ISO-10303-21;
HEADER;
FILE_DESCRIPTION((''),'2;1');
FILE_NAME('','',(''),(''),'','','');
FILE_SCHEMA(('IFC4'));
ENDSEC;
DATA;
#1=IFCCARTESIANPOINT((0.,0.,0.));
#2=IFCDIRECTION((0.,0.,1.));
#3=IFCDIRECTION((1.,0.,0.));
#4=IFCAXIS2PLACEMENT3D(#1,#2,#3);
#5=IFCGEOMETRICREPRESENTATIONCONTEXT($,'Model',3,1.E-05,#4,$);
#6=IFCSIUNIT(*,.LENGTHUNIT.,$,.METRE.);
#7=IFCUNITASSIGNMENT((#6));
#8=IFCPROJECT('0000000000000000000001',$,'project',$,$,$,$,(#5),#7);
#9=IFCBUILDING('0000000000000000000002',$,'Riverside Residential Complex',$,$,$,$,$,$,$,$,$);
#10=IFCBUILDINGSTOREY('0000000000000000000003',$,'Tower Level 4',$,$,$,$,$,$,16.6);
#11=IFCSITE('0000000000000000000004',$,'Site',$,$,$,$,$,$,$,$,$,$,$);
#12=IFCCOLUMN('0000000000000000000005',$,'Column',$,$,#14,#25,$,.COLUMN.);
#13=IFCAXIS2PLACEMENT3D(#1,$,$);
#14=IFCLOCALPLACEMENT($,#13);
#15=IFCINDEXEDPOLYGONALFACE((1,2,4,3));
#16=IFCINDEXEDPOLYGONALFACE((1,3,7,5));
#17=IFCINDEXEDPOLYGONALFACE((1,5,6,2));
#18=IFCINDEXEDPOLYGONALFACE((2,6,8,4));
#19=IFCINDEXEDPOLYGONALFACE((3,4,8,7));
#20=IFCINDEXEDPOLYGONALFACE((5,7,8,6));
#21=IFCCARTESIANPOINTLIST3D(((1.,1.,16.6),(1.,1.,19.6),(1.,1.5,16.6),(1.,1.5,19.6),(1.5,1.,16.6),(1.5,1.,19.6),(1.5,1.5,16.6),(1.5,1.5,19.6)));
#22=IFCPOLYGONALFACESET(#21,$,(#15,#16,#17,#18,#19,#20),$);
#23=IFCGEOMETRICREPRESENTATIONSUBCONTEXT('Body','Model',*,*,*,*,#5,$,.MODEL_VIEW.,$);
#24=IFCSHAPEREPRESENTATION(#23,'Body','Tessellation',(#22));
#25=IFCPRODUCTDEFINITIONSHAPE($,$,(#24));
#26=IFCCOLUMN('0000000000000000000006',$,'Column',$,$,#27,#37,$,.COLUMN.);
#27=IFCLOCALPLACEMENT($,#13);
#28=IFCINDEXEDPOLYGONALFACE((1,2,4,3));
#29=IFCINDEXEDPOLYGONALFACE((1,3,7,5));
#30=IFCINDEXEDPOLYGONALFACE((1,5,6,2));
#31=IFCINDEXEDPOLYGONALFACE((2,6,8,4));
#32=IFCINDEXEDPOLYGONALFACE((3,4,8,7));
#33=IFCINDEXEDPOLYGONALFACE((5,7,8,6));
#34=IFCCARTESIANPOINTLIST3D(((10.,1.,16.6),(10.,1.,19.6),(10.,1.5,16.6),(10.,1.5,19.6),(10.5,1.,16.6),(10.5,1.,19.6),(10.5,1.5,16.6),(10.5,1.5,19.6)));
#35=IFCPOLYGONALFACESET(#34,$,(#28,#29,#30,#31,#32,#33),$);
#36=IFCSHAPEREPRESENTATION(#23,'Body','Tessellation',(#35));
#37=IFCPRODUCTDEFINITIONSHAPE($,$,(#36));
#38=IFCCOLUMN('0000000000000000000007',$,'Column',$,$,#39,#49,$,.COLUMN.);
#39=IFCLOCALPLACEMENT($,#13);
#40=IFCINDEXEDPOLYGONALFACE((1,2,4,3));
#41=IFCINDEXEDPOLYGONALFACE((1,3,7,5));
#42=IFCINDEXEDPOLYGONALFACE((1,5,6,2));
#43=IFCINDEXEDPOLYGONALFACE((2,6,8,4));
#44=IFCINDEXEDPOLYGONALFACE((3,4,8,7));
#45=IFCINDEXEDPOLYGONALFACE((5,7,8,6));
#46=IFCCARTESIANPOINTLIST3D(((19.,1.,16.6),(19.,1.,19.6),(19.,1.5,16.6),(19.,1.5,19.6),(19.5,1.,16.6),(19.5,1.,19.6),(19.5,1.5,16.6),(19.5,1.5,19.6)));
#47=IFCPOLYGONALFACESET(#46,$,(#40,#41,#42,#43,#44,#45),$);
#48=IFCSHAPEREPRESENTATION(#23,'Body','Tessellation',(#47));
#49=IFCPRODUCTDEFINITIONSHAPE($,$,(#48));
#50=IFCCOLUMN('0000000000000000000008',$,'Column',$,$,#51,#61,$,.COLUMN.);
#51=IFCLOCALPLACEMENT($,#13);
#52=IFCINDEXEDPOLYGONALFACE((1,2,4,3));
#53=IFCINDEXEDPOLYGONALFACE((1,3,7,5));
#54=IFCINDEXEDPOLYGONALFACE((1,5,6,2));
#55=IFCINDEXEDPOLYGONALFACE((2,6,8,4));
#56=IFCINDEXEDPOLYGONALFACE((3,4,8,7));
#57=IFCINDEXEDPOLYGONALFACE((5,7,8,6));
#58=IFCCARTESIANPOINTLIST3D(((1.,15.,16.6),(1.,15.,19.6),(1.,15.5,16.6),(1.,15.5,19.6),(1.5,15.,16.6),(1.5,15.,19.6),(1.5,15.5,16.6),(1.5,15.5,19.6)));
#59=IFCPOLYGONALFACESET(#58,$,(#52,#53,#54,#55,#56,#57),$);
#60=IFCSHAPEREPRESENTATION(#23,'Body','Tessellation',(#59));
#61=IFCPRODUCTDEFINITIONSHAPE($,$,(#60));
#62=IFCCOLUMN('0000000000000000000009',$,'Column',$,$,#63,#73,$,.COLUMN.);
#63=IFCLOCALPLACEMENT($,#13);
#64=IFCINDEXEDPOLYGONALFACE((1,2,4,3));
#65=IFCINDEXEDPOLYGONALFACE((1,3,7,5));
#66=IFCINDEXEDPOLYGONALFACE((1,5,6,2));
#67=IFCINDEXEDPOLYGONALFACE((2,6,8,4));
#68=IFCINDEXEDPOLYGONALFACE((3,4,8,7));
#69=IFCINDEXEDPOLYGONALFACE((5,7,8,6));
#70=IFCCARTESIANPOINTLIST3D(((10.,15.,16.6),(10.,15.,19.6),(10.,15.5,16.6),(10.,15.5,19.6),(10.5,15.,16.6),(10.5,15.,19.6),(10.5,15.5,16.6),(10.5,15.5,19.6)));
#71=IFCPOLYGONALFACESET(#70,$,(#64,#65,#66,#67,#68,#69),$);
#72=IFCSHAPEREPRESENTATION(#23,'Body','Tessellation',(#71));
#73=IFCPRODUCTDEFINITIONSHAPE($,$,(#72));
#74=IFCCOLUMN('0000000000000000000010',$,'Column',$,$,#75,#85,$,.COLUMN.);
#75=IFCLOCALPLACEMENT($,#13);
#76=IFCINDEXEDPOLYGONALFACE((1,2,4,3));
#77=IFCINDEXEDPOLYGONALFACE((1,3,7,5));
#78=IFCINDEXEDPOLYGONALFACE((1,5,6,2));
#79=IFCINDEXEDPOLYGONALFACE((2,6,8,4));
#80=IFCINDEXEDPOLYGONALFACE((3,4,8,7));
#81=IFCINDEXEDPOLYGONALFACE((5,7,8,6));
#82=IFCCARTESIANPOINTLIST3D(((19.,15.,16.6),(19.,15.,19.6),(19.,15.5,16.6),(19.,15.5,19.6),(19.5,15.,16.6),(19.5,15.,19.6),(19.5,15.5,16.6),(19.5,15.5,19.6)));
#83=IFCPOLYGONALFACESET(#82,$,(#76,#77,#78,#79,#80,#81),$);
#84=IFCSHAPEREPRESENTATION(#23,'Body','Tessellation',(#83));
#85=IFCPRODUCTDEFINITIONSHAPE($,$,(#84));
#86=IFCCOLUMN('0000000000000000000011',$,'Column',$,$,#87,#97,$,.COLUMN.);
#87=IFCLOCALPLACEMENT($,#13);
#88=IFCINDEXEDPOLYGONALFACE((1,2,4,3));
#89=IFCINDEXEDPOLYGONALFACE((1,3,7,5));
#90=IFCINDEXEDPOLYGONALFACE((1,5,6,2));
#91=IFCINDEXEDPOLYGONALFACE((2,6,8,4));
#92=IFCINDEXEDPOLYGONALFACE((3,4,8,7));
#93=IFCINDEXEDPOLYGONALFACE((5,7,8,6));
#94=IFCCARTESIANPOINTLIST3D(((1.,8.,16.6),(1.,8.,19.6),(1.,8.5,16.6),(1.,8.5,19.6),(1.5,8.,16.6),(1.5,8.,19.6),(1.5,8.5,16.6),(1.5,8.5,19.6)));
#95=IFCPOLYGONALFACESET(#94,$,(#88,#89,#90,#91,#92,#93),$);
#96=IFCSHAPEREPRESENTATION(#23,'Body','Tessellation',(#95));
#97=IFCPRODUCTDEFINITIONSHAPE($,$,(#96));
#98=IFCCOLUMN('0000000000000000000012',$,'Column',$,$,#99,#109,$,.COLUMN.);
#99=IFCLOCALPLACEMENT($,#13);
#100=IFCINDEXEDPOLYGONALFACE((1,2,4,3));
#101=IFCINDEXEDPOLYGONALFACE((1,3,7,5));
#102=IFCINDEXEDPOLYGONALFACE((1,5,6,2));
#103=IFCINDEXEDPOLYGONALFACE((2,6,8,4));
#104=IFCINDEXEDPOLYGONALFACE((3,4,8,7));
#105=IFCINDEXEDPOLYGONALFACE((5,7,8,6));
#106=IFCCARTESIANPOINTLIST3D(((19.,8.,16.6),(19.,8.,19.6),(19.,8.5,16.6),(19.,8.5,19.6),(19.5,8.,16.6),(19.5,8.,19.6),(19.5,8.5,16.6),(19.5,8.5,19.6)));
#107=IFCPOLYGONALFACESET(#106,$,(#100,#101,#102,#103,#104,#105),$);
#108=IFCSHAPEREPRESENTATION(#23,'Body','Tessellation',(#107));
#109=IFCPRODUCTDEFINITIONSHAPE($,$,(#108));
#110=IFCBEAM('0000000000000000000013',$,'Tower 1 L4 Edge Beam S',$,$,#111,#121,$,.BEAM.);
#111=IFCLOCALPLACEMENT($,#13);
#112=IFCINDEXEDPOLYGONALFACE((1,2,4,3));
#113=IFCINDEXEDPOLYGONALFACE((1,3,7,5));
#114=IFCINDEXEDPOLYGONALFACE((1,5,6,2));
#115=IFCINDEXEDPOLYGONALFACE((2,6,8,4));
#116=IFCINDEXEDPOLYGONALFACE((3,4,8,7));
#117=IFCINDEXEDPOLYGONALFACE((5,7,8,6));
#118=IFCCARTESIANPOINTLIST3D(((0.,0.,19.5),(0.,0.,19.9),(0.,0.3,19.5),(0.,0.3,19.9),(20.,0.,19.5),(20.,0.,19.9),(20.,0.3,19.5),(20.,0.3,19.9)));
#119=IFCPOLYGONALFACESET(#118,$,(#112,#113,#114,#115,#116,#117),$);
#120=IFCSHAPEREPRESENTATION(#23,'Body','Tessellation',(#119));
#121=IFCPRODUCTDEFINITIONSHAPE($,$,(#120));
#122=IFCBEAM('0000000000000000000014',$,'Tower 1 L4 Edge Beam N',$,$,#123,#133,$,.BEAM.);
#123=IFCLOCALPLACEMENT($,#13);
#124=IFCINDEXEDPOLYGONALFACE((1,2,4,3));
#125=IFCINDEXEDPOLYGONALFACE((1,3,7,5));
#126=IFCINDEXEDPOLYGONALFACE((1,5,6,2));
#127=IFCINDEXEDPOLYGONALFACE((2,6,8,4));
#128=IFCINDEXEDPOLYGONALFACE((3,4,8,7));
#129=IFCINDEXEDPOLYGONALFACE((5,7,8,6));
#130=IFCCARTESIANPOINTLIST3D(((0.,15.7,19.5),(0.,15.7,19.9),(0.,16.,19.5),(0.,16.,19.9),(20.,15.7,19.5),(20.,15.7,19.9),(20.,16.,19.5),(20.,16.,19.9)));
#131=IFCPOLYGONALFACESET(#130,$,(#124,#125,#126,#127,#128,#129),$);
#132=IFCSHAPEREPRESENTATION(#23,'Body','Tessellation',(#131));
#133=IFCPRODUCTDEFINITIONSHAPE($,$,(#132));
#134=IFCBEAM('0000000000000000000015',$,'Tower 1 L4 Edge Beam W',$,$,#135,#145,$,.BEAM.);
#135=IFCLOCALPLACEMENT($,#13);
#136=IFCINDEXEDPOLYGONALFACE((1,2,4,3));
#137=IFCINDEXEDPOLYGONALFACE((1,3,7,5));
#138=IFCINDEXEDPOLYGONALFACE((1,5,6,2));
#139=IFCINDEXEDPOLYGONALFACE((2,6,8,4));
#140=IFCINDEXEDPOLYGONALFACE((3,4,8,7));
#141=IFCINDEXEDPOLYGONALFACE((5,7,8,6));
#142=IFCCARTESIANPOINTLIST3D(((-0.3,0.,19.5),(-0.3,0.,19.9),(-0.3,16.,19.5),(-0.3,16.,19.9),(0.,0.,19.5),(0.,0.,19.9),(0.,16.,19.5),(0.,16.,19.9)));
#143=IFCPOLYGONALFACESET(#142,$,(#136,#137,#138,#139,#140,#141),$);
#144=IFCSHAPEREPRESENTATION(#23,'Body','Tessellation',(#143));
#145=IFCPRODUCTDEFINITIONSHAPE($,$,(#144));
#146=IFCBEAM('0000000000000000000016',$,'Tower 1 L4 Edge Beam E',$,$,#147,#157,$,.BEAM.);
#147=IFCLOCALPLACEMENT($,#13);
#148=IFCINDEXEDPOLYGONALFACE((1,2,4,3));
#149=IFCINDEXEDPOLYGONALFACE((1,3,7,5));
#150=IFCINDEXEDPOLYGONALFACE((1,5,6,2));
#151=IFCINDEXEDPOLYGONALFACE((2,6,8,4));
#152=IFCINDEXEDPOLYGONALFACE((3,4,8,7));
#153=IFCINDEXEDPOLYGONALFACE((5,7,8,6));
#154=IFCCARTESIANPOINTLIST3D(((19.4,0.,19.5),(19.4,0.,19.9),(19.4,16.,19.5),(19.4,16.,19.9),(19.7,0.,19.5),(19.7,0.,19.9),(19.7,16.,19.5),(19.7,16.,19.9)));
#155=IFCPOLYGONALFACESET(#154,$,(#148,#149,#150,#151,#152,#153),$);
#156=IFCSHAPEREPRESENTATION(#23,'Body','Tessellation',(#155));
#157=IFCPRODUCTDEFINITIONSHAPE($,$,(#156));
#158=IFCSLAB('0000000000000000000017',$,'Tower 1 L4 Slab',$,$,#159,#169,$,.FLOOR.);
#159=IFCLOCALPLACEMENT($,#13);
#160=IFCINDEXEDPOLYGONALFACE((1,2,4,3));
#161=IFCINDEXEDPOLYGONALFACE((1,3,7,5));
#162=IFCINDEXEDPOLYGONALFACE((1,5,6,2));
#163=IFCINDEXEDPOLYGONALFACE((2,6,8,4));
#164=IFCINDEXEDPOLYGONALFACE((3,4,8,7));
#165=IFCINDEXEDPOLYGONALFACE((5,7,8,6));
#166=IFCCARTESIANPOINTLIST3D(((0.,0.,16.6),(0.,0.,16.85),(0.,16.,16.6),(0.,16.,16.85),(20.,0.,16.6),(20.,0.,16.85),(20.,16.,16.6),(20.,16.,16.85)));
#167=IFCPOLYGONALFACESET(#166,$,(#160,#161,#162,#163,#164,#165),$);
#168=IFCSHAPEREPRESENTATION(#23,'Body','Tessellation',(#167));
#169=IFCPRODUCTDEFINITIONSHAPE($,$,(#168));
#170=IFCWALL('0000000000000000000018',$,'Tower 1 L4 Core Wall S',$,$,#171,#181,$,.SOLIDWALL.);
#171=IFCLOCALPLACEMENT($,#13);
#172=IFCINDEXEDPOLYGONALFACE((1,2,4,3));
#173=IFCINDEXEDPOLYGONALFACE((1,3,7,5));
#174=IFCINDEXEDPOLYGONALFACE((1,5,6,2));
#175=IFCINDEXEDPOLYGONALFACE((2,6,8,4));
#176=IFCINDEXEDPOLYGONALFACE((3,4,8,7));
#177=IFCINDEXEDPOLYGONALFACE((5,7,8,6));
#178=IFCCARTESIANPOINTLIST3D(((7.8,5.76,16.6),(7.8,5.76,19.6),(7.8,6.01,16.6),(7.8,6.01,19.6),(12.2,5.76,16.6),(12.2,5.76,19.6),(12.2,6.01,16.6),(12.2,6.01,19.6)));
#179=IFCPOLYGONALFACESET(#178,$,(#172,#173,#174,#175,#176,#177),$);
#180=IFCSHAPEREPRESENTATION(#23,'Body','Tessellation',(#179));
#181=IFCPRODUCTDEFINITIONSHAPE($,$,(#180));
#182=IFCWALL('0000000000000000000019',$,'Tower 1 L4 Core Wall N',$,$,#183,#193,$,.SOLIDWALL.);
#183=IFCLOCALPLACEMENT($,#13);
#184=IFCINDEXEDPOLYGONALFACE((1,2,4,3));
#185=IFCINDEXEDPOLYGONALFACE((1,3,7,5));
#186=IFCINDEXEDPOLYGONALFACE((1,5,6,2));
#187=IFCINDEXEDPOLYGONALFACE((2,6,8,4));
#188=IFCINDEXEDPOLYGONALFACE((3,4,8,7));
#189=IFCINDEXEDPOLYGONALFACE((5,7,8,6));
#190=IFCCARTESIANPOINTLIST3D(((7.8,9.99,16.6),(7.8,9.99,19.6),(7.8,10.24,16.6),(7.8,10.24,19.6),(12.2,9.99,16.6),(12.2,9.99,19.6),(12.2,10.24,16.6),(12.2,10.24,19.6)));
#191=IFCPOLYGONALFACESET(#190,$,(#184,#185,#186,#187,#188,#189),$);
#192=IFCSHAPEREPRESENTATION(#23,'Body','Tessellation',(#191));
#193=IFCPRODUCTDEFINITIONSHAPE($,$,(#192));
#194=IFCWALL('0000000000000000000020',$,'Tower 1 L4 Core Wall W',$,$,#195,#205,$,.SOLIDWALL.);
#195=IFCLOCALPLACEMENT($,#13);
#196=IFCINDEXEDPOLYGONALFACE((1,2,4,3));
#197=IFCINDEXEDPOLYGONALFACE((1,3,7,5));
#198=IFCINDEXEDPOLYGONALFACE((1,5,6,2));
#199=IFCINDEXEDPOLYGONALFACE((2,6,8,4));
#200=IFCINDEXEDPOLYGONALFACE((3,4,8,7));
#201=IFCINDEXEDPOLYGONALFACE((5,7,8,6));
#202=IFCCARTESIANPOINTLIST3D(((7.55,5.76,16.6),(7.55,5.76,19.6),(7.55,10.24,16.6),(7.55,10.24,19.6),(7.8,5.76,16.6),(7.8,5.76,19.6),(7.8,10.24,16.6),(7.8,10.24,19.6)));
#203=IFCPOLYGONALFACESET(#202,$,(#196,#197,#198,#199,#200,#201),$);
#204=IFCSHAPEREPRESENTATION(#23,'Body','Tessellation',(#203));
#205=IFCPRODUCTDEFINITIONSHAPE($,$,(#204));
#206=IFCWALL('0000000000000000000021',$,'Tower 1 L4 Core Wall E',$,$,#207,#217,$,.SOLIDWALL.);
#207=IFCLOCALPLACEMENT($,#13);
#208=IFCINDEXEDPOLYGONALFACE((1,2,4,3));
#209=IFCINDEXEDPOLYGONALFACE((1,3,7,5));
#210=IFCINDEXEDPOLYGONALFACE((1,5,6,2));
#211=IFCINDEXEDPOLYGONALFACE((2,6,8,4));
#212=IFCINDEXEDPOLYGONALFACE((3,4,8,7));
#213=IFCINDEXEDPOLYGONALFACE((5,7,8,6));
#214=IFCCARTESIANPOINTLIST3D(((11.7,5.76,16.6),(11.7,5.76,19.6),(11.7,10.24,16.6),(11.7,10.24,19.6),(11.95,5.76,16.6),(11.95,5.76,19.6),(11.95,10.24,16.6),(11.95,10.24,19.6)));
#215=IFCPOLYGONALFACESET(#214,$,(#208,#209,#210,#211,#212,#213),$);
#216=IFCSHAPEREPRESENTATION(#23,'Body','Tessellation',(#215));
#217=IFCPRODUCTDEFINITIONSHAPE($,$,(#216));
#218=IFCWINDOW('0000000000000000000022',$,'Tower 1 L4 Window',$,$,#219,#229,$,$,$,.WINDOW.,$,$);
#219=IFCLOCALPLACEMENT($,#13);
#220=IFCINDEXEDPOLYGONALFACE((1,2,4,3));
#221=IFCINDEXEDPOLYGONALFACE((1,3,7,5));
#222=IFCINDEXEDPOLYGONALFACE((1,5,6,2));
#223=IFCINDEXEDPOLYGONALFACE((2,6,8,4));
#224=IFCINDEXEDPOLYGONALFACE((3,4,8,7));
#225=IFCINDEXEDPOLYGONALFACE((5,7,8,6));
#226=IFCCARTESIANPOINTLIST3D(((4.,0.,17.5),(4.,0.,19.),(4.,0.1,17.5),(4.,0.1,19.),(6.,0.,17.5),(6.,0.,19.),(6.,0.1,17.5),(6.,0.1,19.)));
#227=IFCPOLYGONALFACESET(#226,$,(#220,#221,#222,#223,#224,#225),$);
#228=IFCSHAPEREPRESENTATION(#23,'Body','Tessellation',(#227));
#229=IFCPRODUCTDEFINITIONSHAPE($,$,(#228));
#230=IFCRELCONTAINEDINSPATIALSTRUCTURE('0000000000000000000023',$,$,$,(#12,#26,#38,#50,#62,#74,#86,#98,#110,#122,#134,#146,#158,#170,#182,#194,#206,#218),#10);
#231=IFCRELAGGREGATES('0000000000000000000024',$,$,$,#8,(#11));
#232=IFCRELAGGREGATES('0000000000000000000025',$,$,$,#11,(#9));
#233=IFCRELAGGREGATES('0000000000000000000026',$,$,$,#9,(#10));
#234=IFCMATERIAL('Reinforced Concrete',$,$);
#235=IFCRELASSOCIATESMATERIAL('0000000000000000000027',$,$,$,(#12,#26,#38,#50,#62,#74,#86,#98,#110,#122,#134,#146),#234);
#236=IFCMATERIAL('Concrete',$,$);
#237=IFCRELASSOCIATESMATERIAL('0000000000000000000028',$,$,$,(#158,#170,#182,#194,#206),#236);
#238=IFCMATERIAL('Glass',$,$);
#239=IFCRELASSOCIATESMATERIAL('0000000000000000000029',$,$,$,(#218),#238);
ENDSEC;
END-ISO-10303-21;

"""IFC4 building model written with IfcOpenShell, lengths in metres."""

from ifc_helpers import new_model, si_unit, frame, origin_with_axes, place, context, subcontext, project, spatial, line, indexed_curve, outline, extrude, material, element, save


model = new_model("IFC4")

# Units and contexts
model_context = context("Model", 3, precision=1e-05, world=origin_with_axes())
body_context = subcontext(model_context, "Body", "Model", "MODEL_VIEW")
ifc_project = project(units=[si_unit("LENGTHUNIT", "METRE")], contexts=[model_context])

# Site, building, storey
site = spatial("IfcSite", under=ifc_project, Name="Site")
building = spatial("IfcBuilding", under=site, Name="Riverside Residential Complex")
storey = spatial("IfcBuildingStorey", under=building, Name="Tower Level 4", Elevation=16.6)

# Columns
ifc_material_1 = material(Name="Reinforced Concrete")
for number, where, z_axis, x_axis, name in (
    (1, (1.0, 1.0, 16.6), (0.0, 0.0, 1.0), (1.0, 0.0, 0.0), "Column"),
    (2, (10.0, 1.0, 16.6), (0.0, 0.0, 1.0), (1.0, 0.0, 0.0), "Column"),
    (3, (19.0, 1.0, 16.6), (0.0, 0.0, 1.0), (1.0, 0.0, 0.0), "Column"),
    (4, (1.0, 15.0, 16.6), (0.0, 0.0, 1.0), (1.0, 0.0, 0.0), "Column"),
    (5, (10.0, 15.0, 16.6), (0.0, 0.0, 1.0), (1.0, 0.0, 0.0), "Column"),
    (6, (19.0, 15.0, 16.6), (0.0, 0.0, 1.0), (1.0, 0.0, 0.0), "Column"),
    (7, (1.0, 8.0, 16.6), (0.0, 0.0, 1.0), (1.0, 0.0, 0.0), "Column"),
    (8, (19.0, 8.0, 16.6), (0.0, 0.0, 1.0), (1.0, 0.0, 0.0), "Column"),
):
    element("IfcColumn", number, at=place(None, frame(where, z_axis=z_axis, x_axis=x_axis)), inside=storey, material=ifc_material_1, Name=name, PredefinedType="COLUMN", context=body_context, shape_type="SweptSolid", body=[
        extrude(outline(indexed_curve([(0.0, 0.0), (0.5, 0.0), (0.5, 0.5), (0.0, 0.5)], segments=[line(1, 2, 3, 4, 1)])), origin_with_axes(), (0.0, 0.0, 1.0), 3.0),
    ])

# Beams
for number, where, z_axis, x_axis, name in (
    (9, (0.0, 0.0, 19.5), (0.0, 0.0, 1.0), (1.0, 0.0, 0.0), "Tower 1 L4 Edge Beam S"),
    (10, (0.0, 15.7, 19.5), (0.0, 0.0, 1.0), (1.0, 0.0, 0.0), "Tower 1 L4 Edge Beam N"),
):
    element("IfcBeam", number, at=place(None, frame(where, z_axis=z_axis, x_axis=x_axis)), inside=storey, material=ifc_material_1, Name=name, PredefinedType="BEAM", context=body_context, shape_type="SweptSolid", body=[
        extrude(outline(indexed_curve([(0.0, 0.0), (20.0, 0.0), (20.0, 0.3), (0.0, 0.3)], segments=[line(1, 2, 3, 4, 1)])), origin_with_axes(), (0.0, 0.0, 1.0), 0.4),
    ])
for number, where, z_axis, x_axis, name in (
    (11, (0.0, 0.0, 19.5), (0.0, 0.0, 1.0), (0.0, 1.0, 0.0), "Tower 1 L4 Edge Beam W"),
    (12, (19.7, 0.0, 19.5), (0.0, 0.0, 1.0), (0.0, 1.0, 0.0), "Tower 1 L4 Edge Beam E"),
):
    element("IfcBeam", number, at=place(None, frame(where, z_axis=z_axis, x_axis=x_axis)), inside=storey, material=ifc_material_1, Name=name, PredefinedType="BEAM", context=body_context, shape_type="SweptSolid", body=[
        extrude(outline(indexed_curve([(0.0, 0.0), (16.0, 0.0), (16.0, 0.3), (0.0, 0.3)], segments=[line(1, 2, 3, 4, 1)])), origin_with_axes(), (0.0, 0.0, 1.0), 0.4),
    ])

# Slab
ifc_material_2 = material(Name="Concrete")
slab_placement = place(None, frame((0.0, 0.0, 16.6), z_axis=(0.0, 0.0, 1.0), x_axis=(1.0, 0.0, 0.0)))
element("IfcSlab", 13, at=slab_placement, inside=storey, material=ifc_material_2, Name="Tower 1 L4 Slab", PredefinedType="FLOOR", context=body_context, shape_type="SweptSolid", body=[
    extrude(outline(indexed_curve([(0.0, 0.0), (20.0, 0.0), (20.0, 16.0), (0.0, 16.0)], segments=[line(1, 2, 3, 4, 1)])), origin_with_axes(), (0.0, 0.0, 1.0), 0.25),
])

# Walls
for number, where, z_axis, x_axis, name in (
    (14, (7.8, 5.76, 16.6), (0.0, 0.0, 1.0), (1.0, 0.0, 0.0), "Tower 1 L4 Core Wall S"),
    (15, (7.8, 9.99, 16.6), (0.0, 0.0, 1.0), (1.0, 0.0, 0.0), "Tower 1 L4 Core Wall N"),
):
    element("IfcWall", number, at=place(None, frame(where, z_axis=z_axis, x_axis=x_axis)), inside=storey, material=ifc_material_2, Name=name, PredefinedType="SOLIDWALL", context=body_context, shape_type="SweptSolid", body=[
        extrude(outline(indexed_curve([(0.0, 0.0), (4.4, 0.0), (4.4, 0.25), (0.0, 0.25)], segments=[line(1, 2, 3, 4, 1)])), origin_with_axes(), (0.0, 0.0, 1.0), 3.0),
    ])
for number, where, z_axis, x_axis, name in (
    (16, (7.8, 5.76, 16.6), (0.0, 0.0, 1.0), (0.0, 1.0, 0.0), "Tower 1 L4 Core Wall W"),
    (17, (11.95, 5.76, 16.6), (0.0, 0.0, 1.0), (0.0, 1.0, 0.0), "Tower 1 L4 Core Wall E"),
):
    element("IfcWall", number, at=place(None, frame(where, z_axis=z_axis, x_axis=x_axis)), inside=storey, material=ifc_material_2, Name=name, PredefinedType="SOLIDWALL", context=body_context, shape_type="SweptSolid", body=[
        extrude(outline(indexed_curve([(0.0, 0.0), (4.48, 0.0), (4.48, 0.25), (0.0, 0.25)], segments=[line(1, 2, 3, 4, 1)])), origin_with_axes(), (0.0, 0.0, 1.0), 3.0),
    ])

# Window
ifc_material_3 = material(Name="Glass")
for number, where, z_axis, x_axis, name in (
    (18, (4.0, 0.0, 17.5), (0.0, 0.0, 1.0), (1.0, 0.0, 0.0), "Tower 1 L4 Window"),
):
    element("IfcWindow", number, at=place(None, frame(where, z_axis=z_axis, x_axis=x_axis)), inside=storey, material=ifc_material_3, Name=name, PredefinedType="WINDOW", context=body_context, shape_type="SweptSolid", body=[
        extrude(outline(indexed_curve([(0.0, 0.0), (2.0, 0.0), (2.0, 0.1), (0.0, 0.1)], segments=[line(1, 2, 3, 4, 1)])), origin_with_axes(), (0.0, 0.0, 1.0), 1.5),
    ])

save(model, "model.ifc")
